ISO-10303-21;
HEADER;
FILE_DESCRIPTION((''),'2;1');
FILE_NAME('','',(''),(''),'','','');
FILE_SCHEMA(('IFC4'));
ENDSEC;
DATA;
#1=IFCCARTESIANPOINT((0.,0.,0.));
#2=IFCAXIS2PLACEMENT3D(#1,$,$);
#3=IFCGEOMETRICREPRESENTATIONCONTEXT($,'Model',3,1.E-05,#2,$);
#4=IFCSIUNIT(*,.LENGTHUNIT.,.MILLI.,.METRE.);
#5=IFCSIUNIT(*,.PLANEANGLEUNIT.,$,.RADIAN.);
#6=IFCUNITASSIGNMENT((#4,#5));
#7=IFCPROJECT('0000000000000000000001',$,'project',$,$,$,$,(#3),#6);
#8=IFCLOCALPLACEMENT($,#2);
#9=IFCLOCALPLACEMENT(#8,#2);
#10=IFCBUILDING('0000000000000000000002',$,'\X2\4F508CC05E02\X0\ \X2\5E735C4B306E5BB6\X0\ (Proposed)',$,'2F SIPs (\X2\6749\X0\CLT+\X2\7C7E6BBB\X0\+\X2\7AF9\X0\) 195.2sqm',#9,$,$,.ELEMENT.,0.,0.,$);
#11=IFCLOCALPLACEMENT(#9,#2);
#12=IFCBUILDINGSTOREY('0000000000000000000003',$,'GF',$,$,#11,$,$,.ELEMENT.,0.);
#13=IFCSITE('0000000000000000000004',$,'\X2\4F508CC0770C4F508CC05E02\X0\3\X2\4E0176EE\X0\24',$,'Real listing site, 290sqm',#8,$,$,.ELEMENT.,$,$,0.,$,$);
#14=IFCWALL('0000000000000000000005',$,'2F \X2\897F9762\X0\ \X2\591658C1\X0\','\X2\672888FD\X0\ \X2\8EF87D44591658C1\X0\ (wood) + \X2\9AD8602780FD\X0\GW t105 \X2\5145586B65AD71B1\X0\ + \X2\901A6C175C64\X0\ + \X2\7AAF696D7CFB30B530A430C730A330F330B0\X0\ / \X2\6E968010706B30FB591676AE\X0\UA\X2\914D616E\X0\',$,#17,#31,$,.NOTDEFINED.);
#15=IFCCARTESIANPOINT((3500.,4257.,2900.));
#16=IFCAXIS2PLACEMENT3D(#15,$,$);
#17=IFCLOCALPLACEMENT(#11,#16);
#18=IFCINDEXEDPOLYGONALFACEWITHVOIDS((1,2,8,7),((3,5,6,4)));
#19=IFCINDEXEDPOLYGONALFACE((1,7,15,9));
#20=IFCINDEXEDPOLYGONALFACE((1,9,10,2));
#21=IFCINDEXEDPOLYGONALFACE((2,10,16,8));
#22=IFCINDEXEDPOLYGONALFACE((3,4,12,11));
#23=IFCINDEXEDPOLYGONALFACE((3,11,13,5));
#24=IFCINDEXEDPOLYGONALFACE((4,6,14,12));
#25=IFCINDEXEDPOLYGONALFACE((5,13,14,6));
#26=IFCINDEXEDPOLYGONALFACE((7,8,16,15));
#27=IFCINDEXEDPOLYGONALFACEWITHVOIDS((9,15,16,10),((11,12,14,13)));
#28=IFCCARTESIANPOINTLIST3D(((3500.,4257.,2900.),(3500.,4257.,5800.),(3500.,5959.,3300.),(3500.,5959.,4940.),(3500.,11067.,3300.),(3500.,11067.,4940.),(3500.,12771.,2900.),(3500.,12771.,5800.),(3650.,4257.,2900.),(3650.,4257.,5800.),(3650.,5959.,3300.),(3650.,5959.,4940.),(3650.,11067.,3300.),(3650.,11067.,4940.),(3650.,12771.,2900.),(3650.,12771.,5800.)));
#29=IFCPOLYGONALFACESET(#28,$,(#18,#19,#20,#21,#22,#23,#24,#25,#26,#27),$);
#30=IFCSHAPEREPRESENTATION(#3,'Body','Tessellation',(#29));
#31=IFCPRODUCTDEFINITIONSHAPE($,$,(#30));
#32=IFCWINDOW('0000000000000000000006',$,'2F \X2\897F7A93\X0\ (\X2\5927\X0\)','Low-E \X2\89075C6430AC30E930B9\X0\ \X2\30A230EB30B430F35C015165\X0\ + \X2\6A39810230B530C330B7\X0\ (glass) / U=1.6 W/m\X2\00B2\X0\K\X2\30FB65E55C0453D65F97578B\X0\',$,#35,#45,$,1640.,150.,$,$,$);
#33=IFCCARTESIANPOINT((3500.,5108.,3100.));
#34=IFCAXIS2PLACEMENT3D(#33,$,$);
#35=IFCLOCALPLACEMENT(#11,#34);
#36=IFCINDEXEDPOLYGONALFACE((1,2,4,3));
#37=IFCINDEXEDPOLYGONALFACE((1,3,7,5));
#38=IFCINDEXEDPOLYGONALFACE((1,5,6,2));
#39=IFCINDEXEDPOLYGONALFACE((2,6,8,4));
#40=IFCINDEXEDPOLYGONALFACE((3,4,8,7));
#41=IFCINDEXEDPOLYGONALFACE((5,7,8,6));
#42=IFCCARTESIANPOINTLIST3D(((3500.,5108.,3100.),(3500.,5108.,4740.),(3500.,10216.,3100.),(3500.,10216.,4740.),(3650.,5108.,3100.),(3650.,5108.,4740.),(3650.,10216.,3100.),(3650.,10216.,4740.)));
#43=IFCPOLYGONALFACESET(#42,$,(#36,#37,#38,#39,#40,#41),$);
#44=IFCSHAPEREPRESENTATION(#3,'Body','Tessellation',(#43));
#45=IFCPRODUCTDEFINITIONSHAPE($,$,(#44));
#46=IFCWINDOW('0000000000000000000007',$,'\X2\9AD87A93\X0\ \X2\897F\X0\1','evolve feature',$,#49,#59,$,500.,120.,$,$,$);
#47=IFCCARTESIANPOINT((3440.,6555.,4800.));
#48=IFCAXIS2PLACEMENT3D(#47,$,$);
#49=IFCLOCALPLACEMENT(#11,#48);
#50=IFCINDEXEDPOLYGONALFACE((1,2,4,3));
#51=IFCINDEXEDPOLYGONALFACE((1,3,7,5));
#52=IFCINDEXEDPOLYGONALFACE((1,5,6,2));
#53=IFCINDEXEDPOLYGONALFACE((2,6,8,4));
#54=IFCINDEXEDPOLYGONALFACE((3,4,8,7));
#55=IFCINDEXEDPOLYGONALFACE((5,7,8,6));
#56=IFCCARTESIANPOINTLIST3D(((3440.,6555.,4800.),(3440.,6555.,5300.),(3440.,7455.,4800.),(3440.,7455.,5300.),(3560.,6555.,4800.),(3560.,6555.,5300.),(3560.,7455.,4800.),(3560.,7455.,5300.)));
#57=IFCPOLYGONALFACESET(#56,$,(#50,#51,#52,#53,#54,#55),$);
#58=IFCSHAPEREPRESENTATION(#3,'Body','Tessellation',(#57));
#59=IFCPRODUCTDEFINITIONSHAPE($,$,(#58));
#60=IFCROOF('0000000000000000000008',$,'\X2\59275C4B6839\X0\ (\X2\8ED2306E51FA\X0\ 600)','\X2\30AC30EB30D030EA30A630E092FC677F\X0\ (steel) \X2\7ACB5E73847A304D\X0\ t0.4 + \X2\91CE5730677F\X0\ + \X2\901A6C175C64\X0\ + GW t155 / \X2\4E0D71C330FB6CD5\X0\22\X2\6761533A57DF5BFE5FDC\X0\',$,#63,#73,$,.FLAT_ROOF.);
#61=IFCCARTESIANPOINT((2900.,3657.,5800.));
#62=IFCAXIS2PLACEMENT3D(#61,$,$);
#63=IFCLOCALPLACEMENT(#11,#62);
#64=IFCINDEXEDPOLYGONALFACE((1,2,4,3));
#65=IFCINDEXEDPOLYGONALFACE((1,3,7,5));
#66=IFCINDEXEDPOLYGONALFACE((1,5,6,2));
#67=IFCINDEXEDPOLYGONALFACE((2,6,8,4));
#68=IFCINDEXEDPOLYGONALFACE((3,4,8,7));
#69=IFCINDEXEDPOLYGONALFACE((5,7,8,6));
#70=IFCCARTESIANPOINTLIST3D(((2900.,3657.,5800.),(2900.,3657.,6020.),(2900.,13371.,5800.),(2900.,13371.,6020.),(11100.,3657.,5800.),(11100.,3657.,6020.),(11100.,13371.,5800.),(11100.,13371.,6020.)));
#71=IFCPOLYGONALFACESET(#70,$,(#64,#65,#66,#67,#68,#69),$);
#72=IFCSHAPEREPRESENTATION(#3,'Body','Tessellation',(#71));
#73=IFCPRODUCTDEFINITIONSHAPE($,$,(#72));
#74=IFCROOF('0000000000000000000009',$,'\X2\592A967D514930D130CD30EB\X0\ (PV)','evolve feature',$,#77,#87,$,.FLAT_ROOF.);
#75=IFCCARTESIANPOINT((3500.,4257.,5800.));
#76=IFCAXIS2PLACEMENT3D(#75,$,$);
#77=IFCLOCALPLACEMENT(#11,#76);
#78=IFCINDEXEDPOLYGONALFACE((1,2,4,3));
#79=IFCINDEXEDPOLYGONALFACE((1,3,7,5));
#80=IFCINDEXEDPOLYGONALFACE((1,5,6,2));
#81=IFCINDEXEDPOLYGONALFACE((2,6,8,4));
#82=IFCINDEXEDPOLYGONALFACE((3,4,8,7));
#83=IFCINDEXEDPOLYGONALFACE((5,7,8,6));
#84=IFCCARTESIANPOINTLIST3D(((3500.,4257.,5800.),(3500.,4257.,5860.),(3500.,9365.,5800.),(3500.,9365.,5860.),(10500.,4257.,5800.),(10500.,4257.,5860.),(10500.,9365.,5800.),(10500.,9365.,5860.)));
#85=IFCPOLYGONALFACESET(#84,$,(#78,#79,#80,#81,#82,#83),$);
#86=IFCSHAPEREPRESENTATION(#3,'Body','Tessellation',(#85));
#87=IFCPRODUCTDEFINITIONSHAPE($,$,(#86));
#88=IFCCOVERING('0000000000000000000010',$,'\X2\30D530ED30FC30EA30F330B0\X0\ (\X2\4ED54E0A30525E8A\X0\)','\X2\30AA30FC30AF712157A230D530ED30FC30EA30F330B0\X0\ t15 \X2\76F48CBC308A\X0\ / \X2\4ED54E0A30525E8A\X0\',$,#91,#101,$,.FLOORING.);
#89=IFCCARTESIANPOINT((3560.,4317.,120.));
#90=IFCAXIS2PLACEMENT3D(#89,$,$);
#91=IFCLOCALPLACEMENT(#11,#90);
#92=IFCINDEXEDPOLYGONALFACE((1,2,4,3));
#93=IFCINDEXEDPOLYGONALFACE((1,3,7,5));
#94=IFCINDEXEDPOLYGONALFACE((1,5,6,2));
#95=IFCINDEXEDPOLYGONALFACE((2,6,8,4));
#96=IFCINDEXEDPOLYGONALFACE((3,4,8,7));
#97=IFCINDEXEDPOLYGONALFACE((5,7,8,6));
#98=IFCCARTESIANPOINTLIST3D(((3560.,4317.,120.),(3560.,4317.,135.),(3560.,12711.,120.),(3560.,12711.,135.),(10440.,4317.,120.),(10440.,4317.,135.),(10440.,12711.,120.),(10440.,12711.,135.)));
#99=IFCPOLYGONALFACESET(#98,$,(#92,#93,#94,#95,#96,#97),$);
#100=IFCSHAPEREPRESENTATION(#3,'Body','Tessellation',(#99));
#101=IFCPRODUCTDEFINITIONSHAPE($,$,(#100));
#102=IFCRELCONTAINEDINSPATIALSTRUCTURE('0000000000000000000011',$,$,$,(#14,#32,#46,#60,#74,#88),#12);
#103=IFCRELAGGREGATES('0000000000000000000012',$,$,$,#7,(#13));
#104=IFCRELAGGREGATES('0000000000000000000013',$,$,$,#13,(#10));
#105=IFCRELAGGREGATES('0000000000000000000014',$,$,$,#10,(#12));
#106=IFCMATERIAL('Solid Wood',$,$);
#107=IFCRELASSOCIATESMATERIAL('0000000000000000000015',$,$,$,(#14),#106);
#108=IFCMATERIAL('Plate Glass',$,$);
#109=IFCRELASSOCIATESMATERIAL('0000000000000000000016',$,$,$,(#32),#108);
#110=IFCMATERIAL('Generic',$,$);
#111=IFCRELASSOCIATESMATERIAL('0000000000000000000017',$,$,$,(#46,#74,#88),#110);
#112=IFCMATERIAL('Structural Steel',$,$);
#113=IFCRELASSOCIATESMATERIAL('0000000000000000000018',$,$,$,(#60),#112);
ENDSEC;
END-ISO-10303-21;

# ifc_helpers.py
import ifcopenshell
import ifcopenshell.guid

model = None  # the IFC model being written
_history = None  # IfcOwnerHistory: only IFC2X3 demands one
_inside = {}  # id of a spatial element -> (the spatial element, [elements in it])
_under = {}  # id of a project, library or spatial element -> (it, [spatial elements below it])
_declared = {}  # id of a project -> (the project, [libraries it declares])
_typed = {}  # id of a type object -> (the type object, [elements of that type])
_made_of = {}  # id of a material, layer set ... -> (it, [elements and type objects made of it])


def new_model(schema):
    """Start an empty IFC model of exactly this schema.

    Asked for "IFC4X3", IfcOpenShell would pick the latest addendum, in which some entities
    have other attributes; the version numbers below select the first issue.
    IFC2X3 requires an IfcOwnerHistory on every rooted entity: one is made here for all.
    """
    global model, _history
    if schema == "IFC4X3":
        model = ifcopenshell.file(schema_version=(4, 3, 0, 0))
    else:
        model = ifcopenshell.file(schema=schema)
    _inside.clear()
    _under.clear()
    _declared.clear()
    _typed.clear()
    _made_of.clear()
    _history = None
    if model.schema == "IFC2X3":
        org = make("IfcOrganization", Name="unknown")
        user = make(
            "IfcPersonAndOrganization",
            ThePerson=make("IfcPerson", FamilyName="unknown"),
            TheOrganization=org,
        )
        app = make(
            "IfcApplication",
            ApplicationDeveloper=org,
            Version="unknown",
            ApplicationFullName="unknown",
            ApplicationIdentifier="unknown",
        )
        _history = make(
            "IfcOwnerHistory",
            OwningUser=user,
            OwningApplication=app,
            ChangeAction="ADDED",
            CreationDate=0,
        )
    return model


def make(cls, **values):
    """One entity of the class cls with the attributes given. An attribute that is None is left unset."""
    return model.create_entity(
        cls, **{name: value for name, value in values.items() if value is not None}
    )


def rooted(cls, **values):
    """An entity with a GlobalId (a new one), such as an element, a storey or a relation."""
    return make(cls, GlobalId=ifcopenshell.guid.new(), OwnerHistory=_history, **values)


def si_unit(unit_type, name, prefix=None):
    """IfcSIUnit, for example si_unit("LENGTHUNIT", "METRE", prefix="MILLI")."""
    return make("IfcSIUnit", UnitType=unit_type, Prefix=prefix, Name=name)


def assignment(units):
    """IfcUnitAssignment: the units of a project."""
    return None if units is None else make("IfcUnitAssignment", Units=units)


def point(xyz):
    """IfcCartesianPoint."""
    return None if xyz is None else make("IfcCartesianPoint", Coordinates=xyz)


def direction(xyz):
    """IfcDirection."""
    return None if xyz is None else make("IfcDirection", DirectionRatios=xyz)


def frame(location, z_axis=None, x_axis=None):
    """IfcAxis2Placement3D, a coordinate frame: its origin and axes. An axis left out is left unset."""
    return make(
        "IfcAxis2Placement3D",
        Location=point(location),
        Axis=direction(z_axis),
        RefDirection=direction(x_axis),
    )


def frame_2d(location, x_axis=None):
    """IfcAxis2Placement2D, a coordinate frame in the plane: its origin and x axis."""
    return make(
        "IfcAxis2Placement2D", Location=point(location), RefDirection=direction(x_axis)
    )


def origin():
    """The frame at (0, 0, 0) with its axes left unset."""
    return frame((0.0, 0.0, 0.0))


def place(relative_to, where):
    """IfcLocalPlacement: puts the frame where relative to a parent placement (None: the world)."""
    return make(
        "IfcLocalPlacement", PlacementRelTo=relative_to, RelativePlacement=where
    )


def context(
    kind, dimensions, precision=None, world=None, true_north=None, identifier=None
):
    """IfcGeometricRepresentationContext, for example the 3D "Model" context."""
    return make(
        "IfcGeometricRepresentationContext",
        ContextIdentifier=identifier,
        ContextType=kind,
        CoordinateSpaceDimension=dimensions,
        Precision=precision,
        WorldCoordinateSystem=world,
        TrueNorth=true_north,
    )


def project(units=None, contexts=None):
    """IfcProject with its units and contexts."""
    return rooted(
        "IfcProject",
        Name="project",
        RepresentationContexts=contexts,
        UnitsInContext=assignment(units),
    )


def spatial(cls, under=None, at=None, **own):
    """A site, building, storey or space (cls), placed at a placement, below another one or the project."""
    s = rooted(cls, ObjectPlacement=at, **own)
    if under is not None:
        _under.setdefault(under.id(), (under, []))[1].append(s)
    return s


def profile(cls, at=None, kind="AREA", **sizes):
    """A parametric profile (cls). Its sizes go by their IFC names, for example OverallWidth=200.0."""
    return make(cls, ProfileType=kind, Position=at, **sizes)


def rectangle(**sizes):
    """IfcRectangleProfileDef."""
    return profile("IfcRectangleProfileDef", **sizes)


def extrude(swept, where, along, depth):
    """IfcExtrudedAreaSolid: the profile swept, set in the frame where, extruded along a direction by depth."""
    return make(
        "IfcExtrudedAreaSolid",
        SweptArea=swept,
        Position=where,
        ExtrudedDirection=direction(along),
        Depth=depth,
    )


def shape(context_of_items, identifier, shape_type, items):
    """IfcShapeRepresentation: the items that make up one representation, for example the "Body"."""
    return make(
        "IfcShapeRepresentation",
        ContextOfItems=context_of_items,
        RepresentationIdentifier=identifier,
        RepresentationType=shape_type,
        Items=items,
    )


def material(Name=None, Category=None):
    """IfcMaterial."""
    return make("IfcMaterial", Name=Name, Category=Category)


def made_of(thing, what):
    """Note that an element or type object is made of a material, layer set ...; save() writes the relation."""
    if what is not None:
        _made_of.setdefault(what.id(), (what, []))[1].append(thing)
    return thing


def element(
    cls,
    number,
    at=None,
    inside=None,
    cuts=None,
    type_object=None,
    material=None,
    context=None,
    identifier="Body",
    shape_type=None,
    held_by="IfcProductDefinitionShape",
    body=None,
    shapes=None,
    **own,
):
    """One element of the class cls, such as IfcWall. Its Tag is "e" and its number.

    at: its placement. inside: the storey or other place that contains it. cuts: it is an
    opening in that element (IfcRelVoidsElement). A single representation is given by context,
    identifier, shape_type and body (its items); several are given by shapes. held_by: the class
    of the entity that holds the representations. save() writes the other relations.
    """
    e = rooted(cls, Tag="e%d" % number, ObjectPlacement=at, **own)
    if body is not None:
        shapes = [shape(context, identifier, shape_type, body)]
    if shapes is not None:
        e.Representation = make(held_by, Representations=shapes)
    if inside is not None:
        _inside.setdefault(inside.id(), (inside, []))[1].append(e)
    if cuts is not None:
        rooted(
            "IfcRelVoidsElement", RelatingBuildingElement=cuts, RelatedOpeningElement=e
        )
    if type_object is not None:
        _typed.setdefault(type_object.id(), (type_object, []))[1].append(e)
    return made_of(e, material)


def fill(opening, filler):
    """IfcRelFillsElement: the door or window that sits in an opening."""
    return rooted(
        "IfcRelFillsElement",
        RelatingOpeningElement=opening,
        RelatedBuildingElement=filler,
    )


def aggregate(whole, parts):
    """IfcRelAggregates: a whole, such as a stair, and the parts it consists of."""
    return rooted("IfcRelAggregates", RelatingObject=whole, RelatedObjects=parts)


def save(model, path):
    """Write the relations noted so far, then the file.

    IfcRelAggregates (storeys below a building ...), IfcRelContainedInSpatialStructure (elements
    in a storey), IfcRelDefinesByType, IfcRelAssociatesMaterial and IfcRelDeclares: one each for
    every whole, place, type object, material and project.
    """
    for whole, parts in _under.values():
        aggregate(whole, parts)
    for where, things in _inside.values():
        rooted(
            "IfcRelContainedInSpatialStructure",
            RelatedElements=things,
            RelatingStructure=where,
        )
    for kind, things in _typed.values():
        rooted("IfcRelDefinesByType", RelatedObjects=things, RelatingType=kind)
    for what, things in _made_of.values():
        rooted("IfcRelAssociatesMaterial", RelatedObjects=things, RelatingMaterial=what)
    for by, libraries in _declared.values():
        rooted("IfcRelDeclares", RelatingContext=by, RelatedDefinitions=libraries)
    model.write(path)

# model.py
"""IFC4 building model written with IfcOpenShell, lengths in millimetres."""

from ifc_helpers import new_model, si_unit, frame, frame_2d, origin, place, context, project, spatial, rectangle, extrude, material, element, fill, save


model = new_model("IFC4")

# Units and contexts
model_context = context("Model", 3, precision=1e-05, world=origin())
ifc_project = project(units=[si_unit("LENGTHUNIT", "METRE", prefix="MILLI"), si_unit("PLANEANGLEUNIT", "RADIAN")], contexts=[model_context])

# Site, building, storey
site_placement = place(None, origin())
site = spatial("IfcSite", under=ifc_project, at=site_placement, Name="佐賀県佐賀市3丁目24", ObjectType="Real listing site, 290sqm", CompositionType="ELEMENT", RefElevation=0.0)
building_placement = place(site_placement, origin())
building = spatial("IfcBuilding", under=site, at=building_placement, Name="佐賀市 平屋の家 (Proposed)", ObjectType="2F SIPs (杉CLT+籾殻+竹) 195.2sqm", CompositionType="ELEMENT", ElevationOfRefHeight=0.0, ElevationOfTerrain=0.0)
storey_placement = place(building_placement, origin())
storey = spatial("IfcBuildingStorey", under=building, at=storey_placement, Name="GF", CompositionType="ELEMENT", Elevation=0.0)

# Shared definitions
ifc_material_1 = material(Name="Solid Wood")

# Shared definitions
ifc_material_2 = material(Name="Plate Glass")
ifc_material_3 = material(Name="Generic")

# Wall, openings, windows
wall_1_placement = place(storey_placement, frame((3500.0, 4257.0, 2900.0)))
wall_1 = element("IfcWall", 1, at=wall_1_placement, inside=storey, material=ifc_material_1, Name="2F 西面 外壁", Description="木製 軸組外壁 (wood) + 高性能GW t105 充填断熱 + 通気層 + 窯業系サイディング / 準耐火・外皮UA配慮", PredefinedType="NOTDEFINED", context=model_context, shape_type="SweptSolid", body=[
    extrude(rectangle(XDim=150.0, YDim=8514.0, at=frame_2d((75.0, 4257.0))), frame((3500.0, 4257.0, 2900.0)), (0.0, 0.0, 1.0), 2900.0),
])
opening_1_placement = place(storey_placement, frame((3500.0, 5108.0, 3100.0)))
opening_1 = element("IfcOpeningElement", 2, at=opening_1_placement, cuts=wall_1, PredefinedType="NOTDEFINED", context=model_context, shape_type="SweptSolid", body=[
    extrude(rectangle(XDim=150.0, YDim=5108.0, at=frame_2d((75.0, 2554.0))), frame((3500.0, 5108.0, 3100.0)), (0.0, 0.0, 1.0), 1640.0),
])
opening_2_placement = place(storey_placement, frame((3440.0, 6555.0, 4800.0)))
opening_2 = element("IfcOpeningElement", 3, at=opening_2_placement, cuts=wall_1, PredefinedType="NOTDEFINED", context=model_context, shape_type="SweptSolid", body=[
    extrude(rectangle(XDim=120.0, YDim=900.0, at=frame_2d((60.0, 450.0))), frame((3440.0, 6555.0, 4800.0)), (0.0, 0.0, 1.0), 500.0),
])
window_1_placement = place(storey_placement, frame((3500.0, 5108.0, 3100.0)))
window_1 = element("IfcWindow", 4, at=window_1_placement, inside=storey, material=ifc_material_2, Name="2F 西窓 (大)", Description="Low-E 複層ガラス アルゴン封入 + 樹脂サッシ (glass) / U=1.6 W/m²K・日射取得型", OverallHeight=1640.0, OverallWidth=150.0, context=model_context, shape_type="SweptSolid", body=[
    extrude(rectangle(XDim=150.0, YDim=5108.0, at=frame_2d((75.0, 2554.0))), frame((3500.0, 5108.0, 3100.0)), (0.0, 0.0, 1.0), 1640.0),
])
fill(opening_1, window_1)
window_2_placement = place(storey_placement, frame((3440.0, 6555.0, 4800.0)))
window_2 = element("IfcWindow", 5, at=window_2_placement, inside=storey, material=ifc_material_3, Name="高窓 西1", Description="evolve feature", OverallHeight=500.0, OverallWidth=120.0, context=model_context, shape_type="SweptSolid", body=[
    extrude(rectangle(XDim=120.0, YDim=900.0, at=frame_2d((60.0, 450.0))), frame((3440.0, 6555.0, 4800.0)), (0.0, 0.0, 1.0), 500.0),
])
fill(opening_2, window_2)

# Roofs
ifc_material_4 = material(Name="Structural Steel")
roof_1_placement = place(storey_placement, frame((2900.0, 3657.0, 5800.0)))
element("IfcRoof", 6, at=roof_1_placement, inside=storey, material=ifc_material_4, Name="大屋根 (軒の出 600)", Description="ガルバリウム鋼板 (steel) 立平葺き t0.4 + 野地板 + 通気層 + GW t155 / 不燃・法22条区域対応", PredefinedType="FLAT_ROOF", context=model_context, shape_type="SweptSolid", body=[
    extrude(rectangle(XDim=8200.0, YDim=9714.0, at=frame_2d((4100.0, 4857.0))), frame((2900.0, 3657.0, 5800.0)), (0.0, 0.0, 1.0), 220.0),
])
roof_2_placement = place(storey_placement, frame((3500.0, 4257.0, 5800.0)))
element("IfcRoof", 7, at=roof_2_placement, inside=storey, material=ifc_material_3, Name="太陽光パネル (PV)", Description="evolve feature", PredefinedType="FLAT_ROOF", context=model_context, shape_type="SweptSolid", body=[
    extrude(rectangle(XDim=7000.0, YDim=5108.0, at=frame_2d((3500.0, 2554.0))), frame((3500.0, 4257.0, 5800.0)), (0.0, 0.0, 1.0), 60.0),
])

# Covering
covering_placement = place(storey_placement, frame((3560.0, 4317.0, 120.0)))
element("IfcCovering", 8, at=covering_placement, inside=storey, material=ifc_material_3, Name="フローリング (仕上げ床)", Description="オーク無垢フローリング t15 直貼り / 仕上げ床", PredefinedType="FLOORING", context=model_context, shape_type="SweptSolid", body=[
    extrude(rectangle(XDim=6880.0, YDim=8394.0, at=frame_2d((3440.0, 4197.0))), frame((3560.0, 4317.0, 120.0)), (0.0, 0.0, 1.0), 15.0),
])

save(model, "model.ifc")
